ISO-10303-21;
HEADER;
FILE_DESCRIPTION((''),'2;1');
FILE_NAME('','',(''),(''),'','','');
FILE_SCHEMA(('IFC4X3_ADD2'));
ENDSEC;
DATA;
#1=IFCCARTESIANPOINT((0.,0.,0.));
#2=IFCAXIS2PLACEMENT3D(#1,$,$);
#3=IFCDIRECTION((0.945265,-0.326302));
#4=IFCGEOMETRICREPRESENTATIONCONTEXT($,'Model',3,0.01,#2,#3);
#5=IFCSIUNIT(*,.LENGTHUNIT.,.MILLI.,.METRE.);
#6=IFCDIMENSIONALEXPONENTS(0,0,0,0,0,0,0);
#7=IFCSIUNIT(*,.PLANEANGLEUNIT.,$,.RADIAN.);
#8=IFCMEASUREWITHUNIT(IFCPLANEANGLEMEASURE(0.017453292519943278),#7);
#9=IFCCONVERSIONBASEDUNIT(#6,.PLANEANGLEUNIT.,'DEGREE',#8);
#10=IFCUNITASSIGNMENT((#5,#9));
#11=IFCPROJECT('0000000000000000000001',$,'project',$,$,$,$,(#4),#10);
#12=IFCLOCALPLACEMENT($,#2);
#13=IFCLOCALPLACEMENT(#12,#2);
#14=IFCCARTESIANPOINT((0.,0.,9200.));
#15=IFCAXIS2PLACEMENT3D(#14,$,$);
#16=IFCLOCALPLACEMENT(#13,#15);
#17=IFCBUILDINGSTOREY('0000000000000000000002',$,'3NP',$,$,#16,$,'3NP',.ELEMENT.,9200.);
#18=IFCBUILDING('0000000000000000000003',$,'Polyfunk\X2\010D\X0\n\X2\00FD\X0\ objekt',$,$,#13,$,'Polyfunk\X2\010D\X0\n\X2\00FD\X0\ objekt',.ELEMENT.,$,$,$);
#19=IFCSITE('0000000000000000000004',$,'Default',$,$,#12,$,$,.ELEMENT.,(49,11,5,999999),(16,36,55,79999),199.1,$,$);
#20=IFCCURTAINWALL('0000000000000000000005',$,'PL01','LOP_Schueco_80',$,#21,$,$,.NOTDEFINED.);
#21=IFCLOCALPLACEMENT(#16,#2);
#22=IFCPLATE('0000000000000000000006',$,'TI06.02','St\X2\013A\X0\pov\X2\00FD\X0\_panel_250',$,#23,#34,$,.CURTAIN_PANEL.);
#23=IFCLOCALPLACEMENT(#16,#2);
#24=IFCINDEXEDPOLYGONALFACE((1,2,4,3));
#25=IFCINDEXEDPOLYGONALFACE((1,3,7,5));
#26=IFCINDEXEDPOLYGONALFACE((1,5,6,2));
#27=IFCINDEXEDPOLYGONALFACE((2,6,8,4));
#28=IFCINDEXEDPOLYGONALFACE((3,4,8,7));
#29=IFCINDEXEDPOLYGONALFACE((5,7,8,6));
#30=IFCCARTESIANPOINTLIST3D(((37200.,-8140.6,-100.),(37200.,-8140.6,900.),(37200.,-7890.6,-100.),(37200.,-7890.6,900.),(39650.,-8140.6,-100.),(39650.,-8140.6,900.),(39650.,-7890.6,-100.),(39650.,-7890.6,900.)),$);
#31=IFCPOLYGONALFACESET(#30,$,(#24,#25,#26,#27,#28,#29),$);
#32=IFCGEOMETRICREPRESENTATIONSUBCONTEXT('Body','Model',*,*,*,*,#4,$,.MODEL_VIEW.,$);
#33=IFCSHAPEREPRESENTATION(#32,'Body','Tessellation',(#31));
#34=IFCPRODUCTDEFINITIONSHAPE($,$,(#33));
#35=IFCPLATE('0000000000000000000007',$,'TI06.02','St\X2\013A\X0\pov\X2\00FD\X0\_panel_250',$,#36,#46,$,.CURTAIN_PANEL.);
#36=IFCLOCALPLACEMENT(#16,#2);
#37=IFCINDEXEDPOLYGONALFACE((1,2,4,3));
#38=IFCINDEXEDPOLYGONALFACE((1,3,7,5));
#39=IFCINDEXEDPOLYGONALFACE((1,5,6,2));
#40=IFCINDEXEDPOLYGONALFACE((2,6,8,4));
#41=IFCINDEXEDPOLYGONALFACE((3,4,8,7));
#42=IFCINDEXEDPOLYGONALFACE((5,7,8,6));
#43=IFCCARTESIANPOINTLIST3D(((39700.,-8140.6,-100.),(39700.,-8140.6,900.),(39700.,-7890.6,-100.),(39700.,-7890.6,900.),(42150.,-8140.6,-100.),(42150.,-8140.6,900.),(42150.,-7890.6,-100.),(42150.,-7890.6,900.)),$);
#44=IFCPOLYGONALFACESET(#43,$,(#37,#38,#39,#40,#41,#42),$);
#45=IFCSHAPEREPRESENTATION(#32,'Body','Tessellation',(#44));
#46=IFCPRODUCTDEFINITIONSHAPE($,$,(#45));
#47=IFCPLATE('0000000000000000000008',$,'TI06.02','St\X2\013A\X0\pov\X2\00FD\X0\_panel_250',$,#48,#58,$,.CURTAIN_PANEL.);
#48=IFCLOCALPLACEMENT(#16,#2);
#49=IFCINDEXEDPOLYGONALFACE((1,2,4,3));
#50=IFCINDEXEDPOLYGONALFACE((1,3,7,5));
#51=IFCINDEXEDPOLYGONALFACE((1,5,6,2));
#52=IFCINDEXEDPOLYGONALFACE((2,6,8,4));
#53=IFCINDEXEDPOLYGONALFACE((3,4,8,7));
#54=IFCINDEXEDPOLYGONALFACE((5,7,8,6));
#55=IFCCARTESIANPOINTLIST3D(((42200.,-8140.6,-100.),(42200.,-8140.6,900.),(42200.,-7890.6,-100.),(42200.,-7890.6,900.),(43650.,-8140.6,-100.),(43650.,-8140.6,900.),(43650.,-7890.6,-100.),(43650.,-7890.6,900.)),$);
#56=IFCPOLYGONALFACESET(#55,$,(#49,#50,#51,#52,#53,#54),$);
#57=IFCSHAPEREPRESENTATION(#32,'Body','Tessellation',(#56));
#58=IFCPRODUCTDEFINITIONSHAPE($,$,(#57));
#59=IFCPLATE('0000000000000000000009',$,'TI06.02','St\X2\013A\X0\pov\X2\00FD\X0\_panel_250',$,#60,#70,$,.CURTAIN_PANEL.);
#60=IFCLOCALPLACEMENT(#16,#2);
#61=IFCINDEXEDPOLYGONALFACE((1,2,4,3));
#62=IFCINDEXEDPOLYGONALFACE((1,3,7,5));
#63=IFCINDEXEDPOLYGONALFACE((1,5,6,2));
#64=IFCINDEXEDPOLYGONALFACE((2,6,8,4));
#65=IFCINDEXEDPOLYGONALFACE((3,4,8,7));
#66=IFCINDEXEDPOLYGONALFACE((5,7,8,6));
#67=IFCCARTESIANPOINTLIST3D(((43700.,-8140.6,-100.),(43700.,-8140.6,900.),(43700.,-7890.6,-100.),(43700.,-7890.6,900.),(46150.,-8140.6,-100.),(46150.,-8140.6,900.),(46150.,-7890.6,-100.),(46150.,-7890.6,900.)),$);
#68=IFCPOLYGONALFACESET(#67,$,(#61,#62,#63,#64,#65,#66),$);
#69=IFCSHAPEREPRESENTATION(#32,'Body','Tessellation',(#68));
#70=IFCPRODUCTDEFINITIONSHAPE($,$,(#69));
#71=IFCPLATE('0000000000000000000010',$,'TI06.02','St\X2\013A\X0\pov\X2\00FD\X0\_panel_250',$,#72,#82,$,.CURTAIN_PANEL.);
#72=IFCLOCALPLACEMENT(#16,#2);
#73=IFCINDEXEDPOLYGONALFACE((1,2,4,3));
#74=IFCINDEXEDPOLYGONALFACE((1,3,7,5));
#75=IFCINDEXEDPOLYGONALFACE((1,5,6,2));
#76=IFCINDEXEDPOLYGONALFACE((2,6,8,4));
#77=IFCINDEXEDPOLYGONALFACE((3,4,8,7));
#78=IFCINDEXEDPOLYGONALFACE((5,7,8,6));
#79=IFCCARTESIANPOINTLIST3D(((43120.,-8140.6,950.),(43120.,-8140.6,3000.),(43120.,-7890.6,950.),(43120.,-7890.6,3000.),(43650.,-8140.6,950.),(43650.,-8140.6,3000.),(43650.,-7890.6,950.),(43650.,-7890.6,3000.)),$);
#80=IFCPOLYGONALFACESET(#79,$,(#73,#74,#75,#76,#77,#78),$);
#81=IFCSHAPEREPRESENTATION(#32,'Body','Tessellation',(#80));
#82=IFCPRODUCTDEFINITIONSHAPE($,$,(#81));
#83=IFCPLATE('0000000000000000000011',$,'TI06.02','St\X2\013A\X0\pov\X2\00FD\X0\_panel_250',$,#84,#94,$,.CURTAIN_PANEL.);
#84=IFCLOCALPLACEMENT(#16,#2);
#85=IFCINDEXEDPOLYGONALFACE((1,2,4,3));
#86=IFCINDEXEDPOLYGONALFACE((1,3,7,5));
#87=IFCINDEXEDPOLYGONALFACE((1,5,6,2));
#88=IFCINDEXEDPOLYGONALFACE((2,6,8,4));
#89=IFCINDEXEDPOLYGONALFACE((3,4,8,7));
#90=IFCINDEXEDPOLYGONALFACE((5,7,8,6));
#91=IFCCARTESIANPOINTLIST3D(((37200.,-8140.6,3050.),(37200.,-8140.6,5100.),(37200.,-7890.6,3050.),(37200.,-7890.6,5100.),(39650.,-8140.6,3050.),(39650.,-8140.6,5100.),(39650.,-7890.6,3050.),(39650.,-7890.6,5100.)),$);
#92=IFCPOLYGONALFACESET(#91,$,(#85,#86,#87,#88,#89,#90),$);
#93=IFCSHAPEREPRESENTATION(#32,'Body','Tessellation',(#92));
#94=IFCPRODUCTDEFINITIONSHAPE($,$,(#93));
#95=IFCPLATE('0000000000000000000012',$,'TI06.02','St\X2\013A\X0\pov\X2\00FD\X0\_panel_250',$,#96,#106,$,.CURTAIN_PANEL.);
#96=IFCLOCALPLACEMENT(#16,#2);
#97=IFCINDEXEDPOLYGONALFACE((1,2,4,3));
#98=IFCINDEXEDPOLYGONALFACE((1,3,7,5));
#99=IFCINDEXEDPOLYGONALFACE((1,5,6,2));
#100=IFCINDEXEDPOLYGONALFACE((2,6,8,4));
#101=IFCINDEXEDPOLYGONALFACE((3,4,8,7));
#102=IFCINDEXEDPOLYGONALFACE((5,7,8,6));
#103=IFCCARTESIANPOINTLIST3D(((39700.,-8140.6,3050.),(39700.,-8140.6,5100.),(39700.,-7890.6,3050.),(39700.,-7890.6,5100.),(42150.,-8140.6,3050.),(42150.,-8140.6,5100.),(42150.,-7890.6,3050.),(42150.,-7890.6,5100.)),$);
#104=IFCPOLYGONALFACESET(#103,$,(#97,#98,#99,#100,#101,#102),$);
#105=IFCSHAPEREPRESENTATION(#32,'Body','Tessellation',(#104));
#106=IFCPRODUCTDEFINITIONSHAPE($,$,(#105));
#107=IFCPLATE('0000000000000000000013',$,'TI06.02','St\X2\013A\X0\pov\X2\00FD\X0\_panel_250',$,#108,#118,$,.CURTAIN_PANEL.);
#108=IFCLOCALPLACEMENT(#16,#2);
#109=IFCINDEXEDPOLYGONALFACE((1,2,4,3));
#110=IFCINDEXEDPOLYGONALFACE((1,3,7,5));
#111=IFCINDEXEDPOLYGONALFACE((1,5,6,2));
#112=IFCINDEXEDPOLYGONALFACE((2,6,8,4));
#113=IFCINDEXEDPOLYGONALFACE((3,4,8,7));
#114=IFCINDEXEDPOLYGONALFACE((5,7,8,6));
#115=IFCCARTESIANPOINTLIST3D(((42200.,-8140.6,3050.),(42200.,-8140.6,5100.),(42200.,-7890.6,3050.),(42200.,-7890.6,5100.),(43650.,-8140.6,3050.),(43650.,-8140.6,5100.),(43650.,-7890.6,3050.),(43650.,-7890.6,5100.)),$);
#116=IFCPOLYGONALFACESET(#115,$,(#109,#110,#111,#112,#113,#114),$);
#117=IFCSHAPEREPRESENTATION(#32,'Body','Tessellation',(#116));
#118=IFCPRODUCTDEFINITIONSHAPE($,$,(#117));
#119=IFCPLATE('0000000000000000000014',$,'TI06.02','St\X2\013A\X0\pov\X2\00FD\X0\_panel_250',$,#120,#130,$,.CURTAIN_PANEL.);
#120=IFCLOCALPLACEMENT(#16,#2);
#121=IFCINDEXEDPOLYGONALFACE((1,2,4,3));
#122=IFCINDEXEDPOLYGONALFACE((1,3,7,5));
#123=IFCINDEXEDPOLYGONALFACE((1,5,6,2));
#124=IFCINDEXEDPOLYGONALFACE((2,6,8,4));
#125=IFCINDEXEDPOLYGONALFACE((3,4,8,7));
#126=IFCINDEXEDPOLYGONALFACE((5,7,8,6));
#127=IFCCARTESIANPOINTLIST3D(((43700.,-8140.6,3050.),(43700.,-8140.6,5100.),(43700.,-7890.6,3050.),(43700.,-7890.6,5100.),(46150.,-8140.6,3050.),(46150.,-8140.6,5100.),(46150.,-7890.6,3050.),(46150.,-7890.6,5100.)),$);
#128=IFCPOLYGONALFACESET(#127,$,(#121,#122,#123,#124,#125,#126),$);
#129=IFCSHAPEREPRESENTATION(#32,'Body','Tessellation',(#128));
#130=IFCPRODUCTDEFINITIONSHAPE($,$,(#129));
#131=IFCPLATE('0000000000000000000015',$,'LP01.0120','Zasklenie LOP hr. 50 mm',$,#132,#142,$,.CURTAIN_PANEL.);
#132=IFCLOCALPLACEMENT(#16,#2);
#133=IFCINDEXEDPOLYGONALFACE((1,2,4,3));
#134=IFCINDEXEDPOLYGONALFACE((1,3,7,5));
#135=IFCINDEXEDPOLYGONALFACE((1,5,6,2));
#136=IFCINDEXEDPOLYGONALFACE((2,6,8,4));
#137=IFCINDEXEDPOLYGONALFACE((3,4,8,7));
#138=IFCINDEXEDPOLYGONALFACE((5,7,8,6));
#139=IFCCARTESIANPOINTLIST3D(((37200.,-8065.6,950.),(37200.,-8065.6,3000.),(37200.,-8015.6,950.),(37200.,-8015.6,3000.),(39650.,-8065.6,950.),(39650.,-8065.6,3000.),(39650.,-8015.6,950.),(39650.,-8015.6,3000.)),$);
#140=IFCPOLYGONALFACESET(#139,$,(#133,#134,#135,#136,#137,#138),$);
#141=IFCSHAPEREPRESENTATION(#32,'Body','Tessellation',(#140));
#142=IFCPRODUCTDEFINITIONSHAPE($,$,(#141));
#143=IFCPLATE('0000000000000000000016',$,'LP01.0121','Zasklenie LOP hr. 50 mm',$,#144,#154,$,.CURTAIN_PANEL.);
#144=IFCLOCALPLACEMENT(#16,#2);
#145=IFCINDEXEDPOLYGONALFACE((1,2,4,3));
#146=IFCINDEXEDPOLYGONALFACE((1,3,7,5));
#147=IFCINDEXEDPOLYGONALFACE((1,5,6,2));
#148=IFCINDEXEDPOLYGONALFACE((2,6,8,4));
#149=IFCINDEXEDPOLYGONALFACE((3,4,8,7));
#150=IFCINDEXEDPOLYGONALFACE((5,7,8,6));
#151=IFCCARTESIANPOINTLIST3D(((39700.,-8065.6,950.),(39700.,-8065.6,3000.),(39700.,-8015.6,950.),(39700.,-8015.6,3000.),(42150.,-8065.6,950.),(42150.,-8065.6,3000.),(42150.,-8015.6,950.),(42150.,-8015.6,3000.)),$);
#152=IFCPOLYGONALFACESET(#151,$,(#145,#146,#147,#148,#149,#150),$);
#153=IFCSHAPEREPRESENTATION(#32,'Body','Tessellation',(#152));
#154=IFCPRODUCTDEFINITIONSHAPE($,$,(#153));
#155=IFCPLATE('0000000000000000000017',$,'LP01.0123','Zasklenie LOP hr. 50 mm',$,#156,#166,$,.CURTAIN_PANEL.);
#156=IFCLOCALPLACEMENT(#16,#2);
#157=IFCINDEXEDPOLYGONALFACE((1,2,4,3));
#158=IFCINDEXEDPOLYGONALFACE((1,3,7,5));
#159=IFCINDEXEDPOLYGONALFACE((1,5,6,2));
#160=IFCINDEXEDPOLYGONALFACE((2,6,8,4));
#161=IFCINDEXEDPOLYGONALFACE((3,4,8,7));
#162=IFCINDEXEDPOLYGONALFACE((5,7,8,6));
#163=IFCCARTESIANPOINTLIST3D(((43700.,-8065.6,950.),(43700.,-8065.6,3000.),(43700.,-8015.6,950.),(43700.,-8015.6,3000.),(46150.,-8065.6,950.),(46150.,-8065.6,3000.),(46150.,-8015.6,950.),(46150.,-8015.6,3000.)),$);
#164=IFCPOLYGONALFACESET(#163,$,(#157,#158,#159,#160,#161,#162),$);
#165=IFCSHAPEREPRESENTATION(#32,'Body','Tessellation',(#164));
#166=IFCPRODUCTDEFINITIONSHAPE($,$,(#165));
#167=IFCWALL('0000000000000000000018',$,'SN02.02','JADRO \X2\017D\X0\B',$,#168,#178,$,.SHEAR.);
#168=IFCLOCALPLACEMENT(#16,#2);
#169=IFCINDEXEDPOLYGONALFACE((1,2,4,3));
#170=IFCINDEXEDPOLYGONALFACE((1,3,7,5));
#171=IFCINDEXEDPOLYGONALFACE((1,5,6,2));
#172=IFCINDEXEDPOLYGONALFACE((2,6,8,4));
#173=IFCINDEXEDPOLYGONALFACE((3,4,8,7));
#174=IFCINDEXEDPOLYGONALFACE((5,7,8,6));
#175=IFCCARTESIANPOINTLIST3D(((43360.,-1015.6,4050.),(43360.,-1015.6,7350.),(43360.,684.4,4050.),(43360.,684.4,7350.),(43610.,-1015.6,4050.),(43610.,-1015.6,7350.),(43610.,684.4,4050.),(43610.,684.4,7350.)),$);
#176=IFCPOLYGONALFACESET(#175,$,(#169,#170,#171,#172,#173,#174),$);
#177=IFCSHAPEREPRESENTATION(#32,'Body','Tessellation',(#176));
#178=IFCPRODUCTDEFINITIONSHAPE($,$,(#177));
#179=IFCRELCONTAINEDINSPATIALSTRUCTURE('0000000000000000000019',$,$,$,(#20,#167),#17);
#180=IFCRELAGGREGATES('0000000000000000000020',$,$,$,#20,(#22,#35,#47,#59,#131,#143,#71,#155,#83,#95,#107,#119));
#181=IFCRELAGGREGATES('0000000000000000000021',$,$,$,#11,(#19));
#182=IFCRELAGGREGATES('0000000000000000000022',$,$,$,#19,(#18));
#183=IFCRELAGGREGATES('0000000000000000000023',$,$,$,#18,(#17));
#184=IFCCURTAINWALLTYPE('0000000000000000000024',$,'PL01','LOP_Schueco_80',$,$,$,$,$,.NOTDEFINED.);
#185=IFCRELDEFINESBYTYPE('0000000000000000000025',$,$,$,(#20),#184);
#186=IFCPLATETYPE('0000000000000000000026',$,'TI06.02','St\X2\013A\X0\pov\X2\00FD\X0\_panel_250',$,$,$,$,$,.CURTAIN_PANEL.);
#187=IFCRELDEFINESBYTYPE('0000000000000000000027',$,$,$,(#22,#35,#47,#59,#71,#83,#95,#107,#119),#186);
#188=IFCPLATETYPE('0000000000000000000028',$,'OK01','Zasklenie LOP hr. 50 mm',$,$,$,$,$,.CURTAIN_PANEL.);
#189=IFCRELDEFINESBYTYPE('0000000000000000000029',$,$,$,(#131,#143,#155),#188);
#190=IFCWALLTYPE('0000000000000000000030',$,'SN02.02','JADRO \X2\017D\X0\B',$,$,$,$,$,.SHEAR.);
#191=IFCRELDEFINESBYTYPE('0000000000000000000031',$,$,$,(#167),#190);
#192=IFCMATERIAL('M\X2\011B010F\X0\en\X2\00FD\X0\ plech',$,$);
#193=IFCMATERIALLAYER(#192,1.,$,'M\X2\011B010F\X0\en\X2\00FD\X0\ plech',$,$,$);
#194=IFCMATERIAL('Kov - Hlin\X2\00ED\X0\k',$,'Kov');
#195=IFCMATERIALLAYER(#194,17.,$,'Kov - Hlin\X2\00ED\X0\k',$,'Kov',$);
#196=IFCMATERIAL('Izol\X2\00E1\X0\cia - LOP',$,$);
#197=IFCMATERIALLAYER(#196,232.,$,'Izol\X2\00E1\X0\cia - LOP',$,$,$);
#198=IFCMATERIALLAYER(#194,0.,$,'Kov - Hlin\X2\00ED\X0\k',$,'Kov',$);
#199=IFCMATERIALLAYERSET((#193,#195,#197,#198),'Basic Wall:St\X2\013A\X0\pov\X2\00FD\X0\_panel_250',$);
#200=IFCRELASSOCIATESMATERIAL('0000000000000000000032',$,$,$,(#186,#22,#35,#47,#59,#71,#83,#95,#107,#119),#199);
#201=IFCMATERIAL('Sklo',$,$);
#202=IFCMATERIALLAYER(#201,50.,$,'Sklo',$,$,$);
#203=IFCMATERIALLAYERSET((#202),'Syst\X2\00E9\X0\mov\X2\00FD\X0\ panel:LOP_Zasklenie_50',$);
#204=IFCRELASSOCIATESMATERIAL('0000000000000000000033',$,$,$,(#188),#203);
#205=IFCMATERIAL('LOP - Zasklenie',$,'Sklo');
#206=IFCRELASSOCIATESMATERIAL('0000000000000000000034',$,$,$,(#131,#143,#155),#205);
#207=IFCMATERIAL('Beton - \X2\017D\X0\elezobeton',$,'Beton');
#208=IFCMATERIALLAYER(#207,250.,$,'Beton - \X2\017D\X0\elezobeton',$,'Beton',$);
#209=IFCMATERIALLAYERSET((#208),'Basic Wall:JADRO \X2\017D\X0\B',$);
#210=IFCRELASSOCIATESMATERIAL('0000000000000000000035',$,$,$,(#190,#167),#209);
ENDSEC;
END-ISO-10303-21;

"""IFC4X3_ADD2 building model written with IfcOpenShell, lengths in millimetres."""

from ifc_helpers import new_model, entity, si_unit, converted_unit, direction, frame, frame_2d, origin, origin_2d_with_axis, place, context, subcontext, project, spatial, polyline, rectangle, extrude, clip, bounded_halfspace, source, transform, mapped, material, layer, layer_set, layer_usage, type_object, type_shapes, element, aggregate, save


model = new_model("IFC4X3_ADD2")

# Units and contexts
model_context = context("Model", 3, precision=0.01, world=origin(), true_north=direction((0.945265, -0.326302)))
body_context = subcontext(model_context, "Body", "Model", "MODEL_VIEW")
ifc_project = project(units=[si_unit("LENGTHUNIT", "METRE", prefix="MILLI"), converted_unit("PLANEANGLEUNIT", "DEGREE", entity("IfcPlaneAngleMeasure", 0.017453292519943278), si_unit("PLANEANGLEUNIT", "RADIAN"), dimensions=[0, 0, 0, 0, 0, 0, 0])], contexts=[model_context])

# Site, building, storey
site_placement = place(None, origin())
site = spatial("IfcSite", under=ifc_project, at=site_placement, Name="Default", CompositionType="ELEMENT", RefLatitude=(49, 11, 5, 999999), RefLongitude=(16, 36, 55, 79999), RefElevation=199.1)
building_placement = place(site_placement, origin())
building = spatial("IfcBuilding", under=site, at=building_placement, Name="Polyfunkčný objekt", LongName="Polyfunkčný objekt", CompositionType="ELEMENT")
storey_placement = place(building_placement, frame((0.0, 0.0, 9200.0)))
storey = spatial("IfcBuildingStorey", under=building, at=storey_placement, Name="3NP", LongName="3NP", CompositionType="ELEMENT", Elevation=9200.0)

# Curtain wall, plates
curtain_wall_type = type_object("IfcCurtainWallType", Name="PL01", Description="LOP_Schueco_80", PredefinedType="NOTDEFINED")
curtain_wall_placement = place(storey_placement, frame((0.0, 0.0, -9200.0)))
curtain_wall = element("IfcCurtainWall", 1, at=curtain_wall_placement, inside=storey, type_object=curtain_wall_type, Name="PL01", Description="LOP_Schueco_80", PredefinedType="NOTDEFINED")
ifc_material_1 = material(Name="Měďený plech")
ifc_layer_1 = layer(ifc_material_1, 1.0, Name="Měďený plech")
ifc_material_2 = material(Name="Kov - Hliník", Category="Kov")
ifc_layer_2 = layer(ifc_material_2, 17.0, Name="Kov - Hliník", Category="Kov")
ifc_material_3 = material(Name="Izolácia - LOP")
ifc_layer_3 = layer(ifc_material_3, 232.0, Name="Izolácia - LOP")
ifc_layer_4 = layer(ifc_material_2, 0.0, Name="Kov - Hliník", Category="Kov")
ifc_layer_set_1 = layer_set([ifc_layer_1, ifc_layer_2, ifc_layer_3, ifc_layer_4], Name="Basic Wall:Stĺpový_panel_250")
ifc_layer_usage_1 = layer_usage(ifc_layer_set_1, "AXIS2", "POSITIVE", -125.0)
plate_type_1 = type_object("IfcPlateType", Name="TI06.02", Description="Stĺpový_panel_250", PredefinedType="CURTAIN_PANEL", material=ifc_layer_set_1)
plate_1_placement = place(storey_placement, frame((37200.0, -8015.6, -100.0)))
plate_1 = element("IfcPlate", 2, at=plate_1_placement, type_object=plate_type_1, material=ifc_layer_usage_1, Name="TI06.02", Description="Stĺpový_panel_250", PredefinedType="CURTAIN_PANEL", context=body_context, shape_type="SweptSolid", body=[
    extrude(rectangle(XDim=250.0, YDim=2450.0, at=frame_2d((0.0, 0.0), x_axis=(1.0, 0.0))), frame((1225.0, 0.0, 0.0), z_axis=(0.0, 0.0, 1.0), x_axis=(0.0, 1.0, 0.0)), (0.0, 0.0, 1.0), 1000.0),
])
ifc_layer_usage_2 = layer_usage(ifc_layer_set_1, "AXIS2", "POSITIVE", -125.0)
plate_2_placement = place(storey_placement, frame((39700.0, -8015.6, -100.0)))
plate_2 = element("IfcPlate", 3, at=plate_2_placement, type_object=plate_type_1, material=ifc_layer_usage_2, Name="TI06.02", Description="Stĺpový_panel_250", PredefinedType="CURTAIN_PANEL", context=body_context, shape_type="SweptSolid", body=[
    extrude(rectangle(XDim=250.0, YDim=2450.0, at=frame_2d((0.0, 0.0), x_axis=(1.0, 0.0))), frame((1225.0, 0.0, 0.0), z_axis=(0.0, 0.0, 1.0), x_axis=(0.0, 1.0, 0.0)), (0.0, 0.0, 1.0), 1000.0),
])
ifc_layer_usage_3 = layer_usage(ifc_layer_set_1, "AXIS2", "POSITIVE", -125.0)
plate_3_placement = place(storey_placement, frame((42200.0, -8015.6, -100.0)))
plate_3 = element("IfcPlate", 4, at=plate_3_placement, type_object=plate_type_1, material=ifc_layer_usage_3, Name="TI06.02", Description="Stĺpový_panel_250", PredefinedType="CURTAIN_PANEL", context=body_context, shape_type="SweptSolid", body=[
    extrude(rectangle(XDim=250.0, YDim=1450.0, at=frame_2d((0.0, 0.0), x_axis=(1.0, 0.0))), frame((725.0, 0.0, 0.0), z_axis=(0.0, 0.0, 1.0), x_axis=(0.0, 1.0, 0.0)), (0.0, 0.0, 1.0), 1000.0),
])
ifc_layer_usage_4 = layer_usage(ifc_layer_set_1, "AXIS2", "POSITIVE", -125.0)
plate_4_placement = place(storey_placement, frame((43700.0, -8015.6, -100.0)))
plate_4 = element("IfcPlate", 5, at=plate_4_placement, type_object=plate_type_1, material=ifc_layer_usage_4, Name="TI06.02", Description="Stĺpový_panel_250", PredefinedType="CURTAIN_PANEL", context=body_context, shape_type="SweptSolid", body=[
    extrude(rectangle(XDim=250.0, YDim=2450.0, at=frame_2d((0.0, 0.0), x_axis=(1.0, 0.0))), frame((1225.0, 0.0, 0.0), z_axis=(0.0, 0.0, 1.0), x_axis=(0.0, 1.0, 0.0)), (0.0, 0.0, 1.0), 1000.0),
])
ifc_layer_usage_5 = layer_usage(ifc_layer_set_1, "AXIS2", "POSITIVE", -125.0)
plate_5_placement = place(storey_placement, frame((43120.0, -8015.6, 950.0)))
plate_5 = element("IfcPlate", 6, at=plate_5_placement, type_object=plate_type_1, material=ifc_layer_usage_5, Name="TI06.02", Description="Stĺpový_panel_250", PredefinedType="CURTAIN_PANEL", context=body_context, shape_type="SweptSolid", body=[
    extrude(rectangle(XDim=250.0, YDim=530.0, at=frame_2d((0.0, 0.0), x_axis=(1.0, 0.0))), frame((265.0, 0.0, 0.0), z_axis=(0.0, 0.0, 1.0), x_axis=(0.0, 1.0, 0.0)), (0.0, 0.0, 1.0), 2050.0),
])
ifc_layer_usage_6 = layer_usage(ifc_layer_set_1, "AXIS2", "POSITIVE", -125.0)
plate_6_placement = place(storey_placement, frame((37200.0, -8015.6, 3050.0)))
plate_6 = element("IfcPlate", 7, at=plate_6_placement, type_object=plate_type_1, material=ifc_layer_usage_6, Name="TI06.02", Description="Stĺpový_panel_250", PredefinedType="CURTAIN_PANEL", context=body_context, shape_type="SweptSolid", body=[
    extrude(rectangle(XDim=250.0, YDim=2450.0, at=frame_2d((0.0, 0.0), x_axis=(1.0, 0.0))), frame((1225.0, 0.0, 0.0), z_axis=(0.0, 0.0, 1.0), x_axis=(0.0, 1.0, 0.0)), (0.0, 0.0, 1.0), 2050.0),
])
ifc_layer_usage_7 = layer_usage(ifc_layer_set_1, "AXIS2", "POSITIVE", -125.0)
plate_7_placement = place(storey_placement, frame((39700.0, -8015.6, 3050.0)))
plate_7 = element("IfcPlate", 8, at=plate_7_placement, type_object=plate_type_1, material=ifc_layer_usage_7, Name="TI06.02", Description="Stĺpový_panel_250", PredefinedType="CURTAIN_PANEL", context=body_context, shape_type="SweptSolid", body=[
    extrude(rectangle(XDim=250.0, YDim=2450.0, at=frame_2d((0.0, 0.0), x_axis=(1.0, 0.0))), frame((1225.0, 0.0, 0.0), z_axis=(0.0, 0.0, 1.0), x_axis=(0.0, 1.0, 0.0)), (0.0, 0.0, 1.0), 2050.0),
])
ifc_layer_usage_8 = layer_usage(ifc_layer_set_1, "AXIS2", "POSITIVE", -125.0)
plate_8_placement = place(storey_placement, frame((42200.0, -8015.6, 3050.0)))
plate_8 = element("IfcPlate", 9, at=plate_8_placement, type_object=plate_type_1, material=ifc_layer_usage_8, Name="TI06.02", Description="Stĺpový_panel_250", PredefinedType="CURTAIN_PANEL", context=body_context, shape_type="SweptSolid", body=[
    extrude(rectangle(XDim=250.0, YDim=1450.0, at=frame_2d((0.0, 0.0), x_axis=(1.0, 0.0))), frame((725.0, 0.0, 0.0), z_axis=(0.0, 0.0, 1.0), x_axis=(0.0, 1.0, 0.0)), (0.0, 0.0, 1.0), 2050.0),
])
ifc_layer_usage_9 = layer_usage(ifc_layer_set_1, "AXIS2", "POSITIVE", -125.0)
plate_9_placement = place(storey_placement, frame((43700.0, -8015.6, 3050.0)))
plate_9 = element("IfcPlate", 10, at=plate_9_placement, type_object=plate_type_1, material=ifc_layer_usage_9, Name="TI06.02", Description="Stĺpový_panel_250", PredefinedType="CURTAIN_PANEL", context=body_context, shape_type="SweptSolid", body=[
    extrude(rectangle(XDim=250.0, YDim=2450.0, at=frame_2d((0.0, 0.0), x_axis=(1.0, 0.0))), frame((1225.0, 0.0, 0.0), z_axis=(0.0, 0.0, 1.0), x_axis=(0.0, 1.0, 0.0)), (0.0, 0.0, 1.0), 2050.0),
])
ifc_material_4 = material(Name="LOP - Zasklenie", Category="Sklo")
ifc_material_5 = material(Name="Sklo")
ifc_layer_5 = layer(ifc_material_5, 50.0, Name="Sklo")
ifc_layer_set_2 = layer_set([ifc_layer_5], Name="Systémový panel:LOP_Zasklenie_50")
plate_type_2 = type_object("IfcPlateType", Name="OK01", Description="Zasklenie LOP hr. 50 mm", PredefinedType="CURTAIN_PANEL", material=ifc_layer_set_2)
shared_shape_1 = source(origin(), body_context, "Body", "SweptSolid", [
    extrude(rectangle(XDim=50.0, YDim=2450.0, at=origin_2d_with_axis()), frame((0.0, -25.0, 0.0), z_axis=(0.0, 0.0, 1.0), x_axis=(0.0, 1.0, 0.0)), (0.0, 0.0, 1.0), 2050.0),
])
type_shapes(plate_type_2, [shared_shape_1])
plate_10_placement = place(curtain_wall_placement, frame((38425.0, -8015.6, 10150.0)))
plate_10 = element("IfcPlate", 11, at=plate_10_placement, type_object=plate_type_2, material=ifc_material_4, Name="LP01.0120", Description="Zasklenie LOP hr. 50 mm", PredefinedType="CURTAIN_PANEL", context=body_context, shape_type="MappedRepresentation", body=[
    mapped(shared_shape_1, transform((0.0, 0.0, 0.0), scale=1.0)),
])
plate_11_placement = place(curtain_wall_placement, frame((40925.0, -8015.6, 10150.0)))
plate_11 = element("IfcPlate", 12, at=plate_11_placement, type_object=plate_type_2, material=ifc_material_4, Name="LP01.0121", Description="Zasklenie LOP hr. 50 mm", PredefinedType="CURTAIN_PANEL", context=body_context, shape_type="MappedRepresentation", body=[
    mapped(shared_shape_1, transform((0.0, 0.0, 0.0), scale=1.0)),
])
plate_12_placement = place(curtain_wall_placement, frame((44925.0, -8015.6, 10150.0)))
plate_12 = element("IfcPlate", 13, at=plate_12_placement, type_object=plate_type_2, material=ifc_material_4, Name="LP01.0123", Description="Zasklenie LOP hr. 50 mm", PredefinedType="CURTAIN_PANEL", context=body_context, shape_type="MappedRepresentation", body=[
    mapped(shared_shape_1, transform((0.0, 0.0, 0.0), scale=1.0)),
])

# Wall
ifc_material_6 = material(Name="Beton - Železobeton", Category="Beton")
ifc_layer_6 = layer(ifc_material_6, 250.0, Name="Beton - Železobeton", Category="Beton")
ifc_layer_set_3 = layer_set([ifc_layer_6], Name="Basic Wall:JADRO ŽB")
wall_type = type_object("IfcWallType", Name="SN02.02", Description="JADRO ŽB", PredefinedType="SHEAR", material=ifc_layer_set_3)
wall_1_placement = place(storey_placement, frame((43485.0, 684.4, 4050.0), z_axis=(0.0, 0.0, 1.0), x_axis=(0.0, -1.0, 0.0)))
element("IfcWall", 14, at=wall_1_placement, inside=storey, type_object=wall_type, material=ifc_layer_set_3, Name="SN02.02", Description="JADRO ŽB", PredefinedType="SHEAR", context=body_context, shape_type="Clipping", body=[
    clip(clip(extrude(rectangle(XDim=1700.0, YDim=250.0, at=frame_2d((850.0, 0.0), x_axis=(-1.0, 0.0))), origin(), (0.0, 0.0, 1.0), 3300.0), bounded_halfspace(frame((1700.0, -125.0, 0.0), z_axis=(0.0, 0.0, 1.0), x_axis=(0.0, -1.0, 0.0)), True, frame((1700.0, -125.0, 0.0)), polyline([(0.0, 0.0), (0.0, 250.0), (-1700.0, 250.0), (-1700.0, 0.0), (0.0, 0.0)]))), bounded_halfspace(frame((0.0, -125.0, 3300.0), z_axis=(0.0, 0.0, -1.0), x_axis=(1.0, 0.0, 0.0)), True, frame((0.0, -125.0, 3300.0)), polyline([(0.0, 0.0), (1700.0, 0.0), (1700.0, 250.0), (0.0, 250.0), (0.0, 0.0)]))),
])

aggregate(curtain_wall, [plate_1, plate_2, plate_3, plate_4, plate_10, plate_11, plate_5, plate_12, plate_6, plate_7, plate_8, plate_9])

save(model, "model.ifc")
